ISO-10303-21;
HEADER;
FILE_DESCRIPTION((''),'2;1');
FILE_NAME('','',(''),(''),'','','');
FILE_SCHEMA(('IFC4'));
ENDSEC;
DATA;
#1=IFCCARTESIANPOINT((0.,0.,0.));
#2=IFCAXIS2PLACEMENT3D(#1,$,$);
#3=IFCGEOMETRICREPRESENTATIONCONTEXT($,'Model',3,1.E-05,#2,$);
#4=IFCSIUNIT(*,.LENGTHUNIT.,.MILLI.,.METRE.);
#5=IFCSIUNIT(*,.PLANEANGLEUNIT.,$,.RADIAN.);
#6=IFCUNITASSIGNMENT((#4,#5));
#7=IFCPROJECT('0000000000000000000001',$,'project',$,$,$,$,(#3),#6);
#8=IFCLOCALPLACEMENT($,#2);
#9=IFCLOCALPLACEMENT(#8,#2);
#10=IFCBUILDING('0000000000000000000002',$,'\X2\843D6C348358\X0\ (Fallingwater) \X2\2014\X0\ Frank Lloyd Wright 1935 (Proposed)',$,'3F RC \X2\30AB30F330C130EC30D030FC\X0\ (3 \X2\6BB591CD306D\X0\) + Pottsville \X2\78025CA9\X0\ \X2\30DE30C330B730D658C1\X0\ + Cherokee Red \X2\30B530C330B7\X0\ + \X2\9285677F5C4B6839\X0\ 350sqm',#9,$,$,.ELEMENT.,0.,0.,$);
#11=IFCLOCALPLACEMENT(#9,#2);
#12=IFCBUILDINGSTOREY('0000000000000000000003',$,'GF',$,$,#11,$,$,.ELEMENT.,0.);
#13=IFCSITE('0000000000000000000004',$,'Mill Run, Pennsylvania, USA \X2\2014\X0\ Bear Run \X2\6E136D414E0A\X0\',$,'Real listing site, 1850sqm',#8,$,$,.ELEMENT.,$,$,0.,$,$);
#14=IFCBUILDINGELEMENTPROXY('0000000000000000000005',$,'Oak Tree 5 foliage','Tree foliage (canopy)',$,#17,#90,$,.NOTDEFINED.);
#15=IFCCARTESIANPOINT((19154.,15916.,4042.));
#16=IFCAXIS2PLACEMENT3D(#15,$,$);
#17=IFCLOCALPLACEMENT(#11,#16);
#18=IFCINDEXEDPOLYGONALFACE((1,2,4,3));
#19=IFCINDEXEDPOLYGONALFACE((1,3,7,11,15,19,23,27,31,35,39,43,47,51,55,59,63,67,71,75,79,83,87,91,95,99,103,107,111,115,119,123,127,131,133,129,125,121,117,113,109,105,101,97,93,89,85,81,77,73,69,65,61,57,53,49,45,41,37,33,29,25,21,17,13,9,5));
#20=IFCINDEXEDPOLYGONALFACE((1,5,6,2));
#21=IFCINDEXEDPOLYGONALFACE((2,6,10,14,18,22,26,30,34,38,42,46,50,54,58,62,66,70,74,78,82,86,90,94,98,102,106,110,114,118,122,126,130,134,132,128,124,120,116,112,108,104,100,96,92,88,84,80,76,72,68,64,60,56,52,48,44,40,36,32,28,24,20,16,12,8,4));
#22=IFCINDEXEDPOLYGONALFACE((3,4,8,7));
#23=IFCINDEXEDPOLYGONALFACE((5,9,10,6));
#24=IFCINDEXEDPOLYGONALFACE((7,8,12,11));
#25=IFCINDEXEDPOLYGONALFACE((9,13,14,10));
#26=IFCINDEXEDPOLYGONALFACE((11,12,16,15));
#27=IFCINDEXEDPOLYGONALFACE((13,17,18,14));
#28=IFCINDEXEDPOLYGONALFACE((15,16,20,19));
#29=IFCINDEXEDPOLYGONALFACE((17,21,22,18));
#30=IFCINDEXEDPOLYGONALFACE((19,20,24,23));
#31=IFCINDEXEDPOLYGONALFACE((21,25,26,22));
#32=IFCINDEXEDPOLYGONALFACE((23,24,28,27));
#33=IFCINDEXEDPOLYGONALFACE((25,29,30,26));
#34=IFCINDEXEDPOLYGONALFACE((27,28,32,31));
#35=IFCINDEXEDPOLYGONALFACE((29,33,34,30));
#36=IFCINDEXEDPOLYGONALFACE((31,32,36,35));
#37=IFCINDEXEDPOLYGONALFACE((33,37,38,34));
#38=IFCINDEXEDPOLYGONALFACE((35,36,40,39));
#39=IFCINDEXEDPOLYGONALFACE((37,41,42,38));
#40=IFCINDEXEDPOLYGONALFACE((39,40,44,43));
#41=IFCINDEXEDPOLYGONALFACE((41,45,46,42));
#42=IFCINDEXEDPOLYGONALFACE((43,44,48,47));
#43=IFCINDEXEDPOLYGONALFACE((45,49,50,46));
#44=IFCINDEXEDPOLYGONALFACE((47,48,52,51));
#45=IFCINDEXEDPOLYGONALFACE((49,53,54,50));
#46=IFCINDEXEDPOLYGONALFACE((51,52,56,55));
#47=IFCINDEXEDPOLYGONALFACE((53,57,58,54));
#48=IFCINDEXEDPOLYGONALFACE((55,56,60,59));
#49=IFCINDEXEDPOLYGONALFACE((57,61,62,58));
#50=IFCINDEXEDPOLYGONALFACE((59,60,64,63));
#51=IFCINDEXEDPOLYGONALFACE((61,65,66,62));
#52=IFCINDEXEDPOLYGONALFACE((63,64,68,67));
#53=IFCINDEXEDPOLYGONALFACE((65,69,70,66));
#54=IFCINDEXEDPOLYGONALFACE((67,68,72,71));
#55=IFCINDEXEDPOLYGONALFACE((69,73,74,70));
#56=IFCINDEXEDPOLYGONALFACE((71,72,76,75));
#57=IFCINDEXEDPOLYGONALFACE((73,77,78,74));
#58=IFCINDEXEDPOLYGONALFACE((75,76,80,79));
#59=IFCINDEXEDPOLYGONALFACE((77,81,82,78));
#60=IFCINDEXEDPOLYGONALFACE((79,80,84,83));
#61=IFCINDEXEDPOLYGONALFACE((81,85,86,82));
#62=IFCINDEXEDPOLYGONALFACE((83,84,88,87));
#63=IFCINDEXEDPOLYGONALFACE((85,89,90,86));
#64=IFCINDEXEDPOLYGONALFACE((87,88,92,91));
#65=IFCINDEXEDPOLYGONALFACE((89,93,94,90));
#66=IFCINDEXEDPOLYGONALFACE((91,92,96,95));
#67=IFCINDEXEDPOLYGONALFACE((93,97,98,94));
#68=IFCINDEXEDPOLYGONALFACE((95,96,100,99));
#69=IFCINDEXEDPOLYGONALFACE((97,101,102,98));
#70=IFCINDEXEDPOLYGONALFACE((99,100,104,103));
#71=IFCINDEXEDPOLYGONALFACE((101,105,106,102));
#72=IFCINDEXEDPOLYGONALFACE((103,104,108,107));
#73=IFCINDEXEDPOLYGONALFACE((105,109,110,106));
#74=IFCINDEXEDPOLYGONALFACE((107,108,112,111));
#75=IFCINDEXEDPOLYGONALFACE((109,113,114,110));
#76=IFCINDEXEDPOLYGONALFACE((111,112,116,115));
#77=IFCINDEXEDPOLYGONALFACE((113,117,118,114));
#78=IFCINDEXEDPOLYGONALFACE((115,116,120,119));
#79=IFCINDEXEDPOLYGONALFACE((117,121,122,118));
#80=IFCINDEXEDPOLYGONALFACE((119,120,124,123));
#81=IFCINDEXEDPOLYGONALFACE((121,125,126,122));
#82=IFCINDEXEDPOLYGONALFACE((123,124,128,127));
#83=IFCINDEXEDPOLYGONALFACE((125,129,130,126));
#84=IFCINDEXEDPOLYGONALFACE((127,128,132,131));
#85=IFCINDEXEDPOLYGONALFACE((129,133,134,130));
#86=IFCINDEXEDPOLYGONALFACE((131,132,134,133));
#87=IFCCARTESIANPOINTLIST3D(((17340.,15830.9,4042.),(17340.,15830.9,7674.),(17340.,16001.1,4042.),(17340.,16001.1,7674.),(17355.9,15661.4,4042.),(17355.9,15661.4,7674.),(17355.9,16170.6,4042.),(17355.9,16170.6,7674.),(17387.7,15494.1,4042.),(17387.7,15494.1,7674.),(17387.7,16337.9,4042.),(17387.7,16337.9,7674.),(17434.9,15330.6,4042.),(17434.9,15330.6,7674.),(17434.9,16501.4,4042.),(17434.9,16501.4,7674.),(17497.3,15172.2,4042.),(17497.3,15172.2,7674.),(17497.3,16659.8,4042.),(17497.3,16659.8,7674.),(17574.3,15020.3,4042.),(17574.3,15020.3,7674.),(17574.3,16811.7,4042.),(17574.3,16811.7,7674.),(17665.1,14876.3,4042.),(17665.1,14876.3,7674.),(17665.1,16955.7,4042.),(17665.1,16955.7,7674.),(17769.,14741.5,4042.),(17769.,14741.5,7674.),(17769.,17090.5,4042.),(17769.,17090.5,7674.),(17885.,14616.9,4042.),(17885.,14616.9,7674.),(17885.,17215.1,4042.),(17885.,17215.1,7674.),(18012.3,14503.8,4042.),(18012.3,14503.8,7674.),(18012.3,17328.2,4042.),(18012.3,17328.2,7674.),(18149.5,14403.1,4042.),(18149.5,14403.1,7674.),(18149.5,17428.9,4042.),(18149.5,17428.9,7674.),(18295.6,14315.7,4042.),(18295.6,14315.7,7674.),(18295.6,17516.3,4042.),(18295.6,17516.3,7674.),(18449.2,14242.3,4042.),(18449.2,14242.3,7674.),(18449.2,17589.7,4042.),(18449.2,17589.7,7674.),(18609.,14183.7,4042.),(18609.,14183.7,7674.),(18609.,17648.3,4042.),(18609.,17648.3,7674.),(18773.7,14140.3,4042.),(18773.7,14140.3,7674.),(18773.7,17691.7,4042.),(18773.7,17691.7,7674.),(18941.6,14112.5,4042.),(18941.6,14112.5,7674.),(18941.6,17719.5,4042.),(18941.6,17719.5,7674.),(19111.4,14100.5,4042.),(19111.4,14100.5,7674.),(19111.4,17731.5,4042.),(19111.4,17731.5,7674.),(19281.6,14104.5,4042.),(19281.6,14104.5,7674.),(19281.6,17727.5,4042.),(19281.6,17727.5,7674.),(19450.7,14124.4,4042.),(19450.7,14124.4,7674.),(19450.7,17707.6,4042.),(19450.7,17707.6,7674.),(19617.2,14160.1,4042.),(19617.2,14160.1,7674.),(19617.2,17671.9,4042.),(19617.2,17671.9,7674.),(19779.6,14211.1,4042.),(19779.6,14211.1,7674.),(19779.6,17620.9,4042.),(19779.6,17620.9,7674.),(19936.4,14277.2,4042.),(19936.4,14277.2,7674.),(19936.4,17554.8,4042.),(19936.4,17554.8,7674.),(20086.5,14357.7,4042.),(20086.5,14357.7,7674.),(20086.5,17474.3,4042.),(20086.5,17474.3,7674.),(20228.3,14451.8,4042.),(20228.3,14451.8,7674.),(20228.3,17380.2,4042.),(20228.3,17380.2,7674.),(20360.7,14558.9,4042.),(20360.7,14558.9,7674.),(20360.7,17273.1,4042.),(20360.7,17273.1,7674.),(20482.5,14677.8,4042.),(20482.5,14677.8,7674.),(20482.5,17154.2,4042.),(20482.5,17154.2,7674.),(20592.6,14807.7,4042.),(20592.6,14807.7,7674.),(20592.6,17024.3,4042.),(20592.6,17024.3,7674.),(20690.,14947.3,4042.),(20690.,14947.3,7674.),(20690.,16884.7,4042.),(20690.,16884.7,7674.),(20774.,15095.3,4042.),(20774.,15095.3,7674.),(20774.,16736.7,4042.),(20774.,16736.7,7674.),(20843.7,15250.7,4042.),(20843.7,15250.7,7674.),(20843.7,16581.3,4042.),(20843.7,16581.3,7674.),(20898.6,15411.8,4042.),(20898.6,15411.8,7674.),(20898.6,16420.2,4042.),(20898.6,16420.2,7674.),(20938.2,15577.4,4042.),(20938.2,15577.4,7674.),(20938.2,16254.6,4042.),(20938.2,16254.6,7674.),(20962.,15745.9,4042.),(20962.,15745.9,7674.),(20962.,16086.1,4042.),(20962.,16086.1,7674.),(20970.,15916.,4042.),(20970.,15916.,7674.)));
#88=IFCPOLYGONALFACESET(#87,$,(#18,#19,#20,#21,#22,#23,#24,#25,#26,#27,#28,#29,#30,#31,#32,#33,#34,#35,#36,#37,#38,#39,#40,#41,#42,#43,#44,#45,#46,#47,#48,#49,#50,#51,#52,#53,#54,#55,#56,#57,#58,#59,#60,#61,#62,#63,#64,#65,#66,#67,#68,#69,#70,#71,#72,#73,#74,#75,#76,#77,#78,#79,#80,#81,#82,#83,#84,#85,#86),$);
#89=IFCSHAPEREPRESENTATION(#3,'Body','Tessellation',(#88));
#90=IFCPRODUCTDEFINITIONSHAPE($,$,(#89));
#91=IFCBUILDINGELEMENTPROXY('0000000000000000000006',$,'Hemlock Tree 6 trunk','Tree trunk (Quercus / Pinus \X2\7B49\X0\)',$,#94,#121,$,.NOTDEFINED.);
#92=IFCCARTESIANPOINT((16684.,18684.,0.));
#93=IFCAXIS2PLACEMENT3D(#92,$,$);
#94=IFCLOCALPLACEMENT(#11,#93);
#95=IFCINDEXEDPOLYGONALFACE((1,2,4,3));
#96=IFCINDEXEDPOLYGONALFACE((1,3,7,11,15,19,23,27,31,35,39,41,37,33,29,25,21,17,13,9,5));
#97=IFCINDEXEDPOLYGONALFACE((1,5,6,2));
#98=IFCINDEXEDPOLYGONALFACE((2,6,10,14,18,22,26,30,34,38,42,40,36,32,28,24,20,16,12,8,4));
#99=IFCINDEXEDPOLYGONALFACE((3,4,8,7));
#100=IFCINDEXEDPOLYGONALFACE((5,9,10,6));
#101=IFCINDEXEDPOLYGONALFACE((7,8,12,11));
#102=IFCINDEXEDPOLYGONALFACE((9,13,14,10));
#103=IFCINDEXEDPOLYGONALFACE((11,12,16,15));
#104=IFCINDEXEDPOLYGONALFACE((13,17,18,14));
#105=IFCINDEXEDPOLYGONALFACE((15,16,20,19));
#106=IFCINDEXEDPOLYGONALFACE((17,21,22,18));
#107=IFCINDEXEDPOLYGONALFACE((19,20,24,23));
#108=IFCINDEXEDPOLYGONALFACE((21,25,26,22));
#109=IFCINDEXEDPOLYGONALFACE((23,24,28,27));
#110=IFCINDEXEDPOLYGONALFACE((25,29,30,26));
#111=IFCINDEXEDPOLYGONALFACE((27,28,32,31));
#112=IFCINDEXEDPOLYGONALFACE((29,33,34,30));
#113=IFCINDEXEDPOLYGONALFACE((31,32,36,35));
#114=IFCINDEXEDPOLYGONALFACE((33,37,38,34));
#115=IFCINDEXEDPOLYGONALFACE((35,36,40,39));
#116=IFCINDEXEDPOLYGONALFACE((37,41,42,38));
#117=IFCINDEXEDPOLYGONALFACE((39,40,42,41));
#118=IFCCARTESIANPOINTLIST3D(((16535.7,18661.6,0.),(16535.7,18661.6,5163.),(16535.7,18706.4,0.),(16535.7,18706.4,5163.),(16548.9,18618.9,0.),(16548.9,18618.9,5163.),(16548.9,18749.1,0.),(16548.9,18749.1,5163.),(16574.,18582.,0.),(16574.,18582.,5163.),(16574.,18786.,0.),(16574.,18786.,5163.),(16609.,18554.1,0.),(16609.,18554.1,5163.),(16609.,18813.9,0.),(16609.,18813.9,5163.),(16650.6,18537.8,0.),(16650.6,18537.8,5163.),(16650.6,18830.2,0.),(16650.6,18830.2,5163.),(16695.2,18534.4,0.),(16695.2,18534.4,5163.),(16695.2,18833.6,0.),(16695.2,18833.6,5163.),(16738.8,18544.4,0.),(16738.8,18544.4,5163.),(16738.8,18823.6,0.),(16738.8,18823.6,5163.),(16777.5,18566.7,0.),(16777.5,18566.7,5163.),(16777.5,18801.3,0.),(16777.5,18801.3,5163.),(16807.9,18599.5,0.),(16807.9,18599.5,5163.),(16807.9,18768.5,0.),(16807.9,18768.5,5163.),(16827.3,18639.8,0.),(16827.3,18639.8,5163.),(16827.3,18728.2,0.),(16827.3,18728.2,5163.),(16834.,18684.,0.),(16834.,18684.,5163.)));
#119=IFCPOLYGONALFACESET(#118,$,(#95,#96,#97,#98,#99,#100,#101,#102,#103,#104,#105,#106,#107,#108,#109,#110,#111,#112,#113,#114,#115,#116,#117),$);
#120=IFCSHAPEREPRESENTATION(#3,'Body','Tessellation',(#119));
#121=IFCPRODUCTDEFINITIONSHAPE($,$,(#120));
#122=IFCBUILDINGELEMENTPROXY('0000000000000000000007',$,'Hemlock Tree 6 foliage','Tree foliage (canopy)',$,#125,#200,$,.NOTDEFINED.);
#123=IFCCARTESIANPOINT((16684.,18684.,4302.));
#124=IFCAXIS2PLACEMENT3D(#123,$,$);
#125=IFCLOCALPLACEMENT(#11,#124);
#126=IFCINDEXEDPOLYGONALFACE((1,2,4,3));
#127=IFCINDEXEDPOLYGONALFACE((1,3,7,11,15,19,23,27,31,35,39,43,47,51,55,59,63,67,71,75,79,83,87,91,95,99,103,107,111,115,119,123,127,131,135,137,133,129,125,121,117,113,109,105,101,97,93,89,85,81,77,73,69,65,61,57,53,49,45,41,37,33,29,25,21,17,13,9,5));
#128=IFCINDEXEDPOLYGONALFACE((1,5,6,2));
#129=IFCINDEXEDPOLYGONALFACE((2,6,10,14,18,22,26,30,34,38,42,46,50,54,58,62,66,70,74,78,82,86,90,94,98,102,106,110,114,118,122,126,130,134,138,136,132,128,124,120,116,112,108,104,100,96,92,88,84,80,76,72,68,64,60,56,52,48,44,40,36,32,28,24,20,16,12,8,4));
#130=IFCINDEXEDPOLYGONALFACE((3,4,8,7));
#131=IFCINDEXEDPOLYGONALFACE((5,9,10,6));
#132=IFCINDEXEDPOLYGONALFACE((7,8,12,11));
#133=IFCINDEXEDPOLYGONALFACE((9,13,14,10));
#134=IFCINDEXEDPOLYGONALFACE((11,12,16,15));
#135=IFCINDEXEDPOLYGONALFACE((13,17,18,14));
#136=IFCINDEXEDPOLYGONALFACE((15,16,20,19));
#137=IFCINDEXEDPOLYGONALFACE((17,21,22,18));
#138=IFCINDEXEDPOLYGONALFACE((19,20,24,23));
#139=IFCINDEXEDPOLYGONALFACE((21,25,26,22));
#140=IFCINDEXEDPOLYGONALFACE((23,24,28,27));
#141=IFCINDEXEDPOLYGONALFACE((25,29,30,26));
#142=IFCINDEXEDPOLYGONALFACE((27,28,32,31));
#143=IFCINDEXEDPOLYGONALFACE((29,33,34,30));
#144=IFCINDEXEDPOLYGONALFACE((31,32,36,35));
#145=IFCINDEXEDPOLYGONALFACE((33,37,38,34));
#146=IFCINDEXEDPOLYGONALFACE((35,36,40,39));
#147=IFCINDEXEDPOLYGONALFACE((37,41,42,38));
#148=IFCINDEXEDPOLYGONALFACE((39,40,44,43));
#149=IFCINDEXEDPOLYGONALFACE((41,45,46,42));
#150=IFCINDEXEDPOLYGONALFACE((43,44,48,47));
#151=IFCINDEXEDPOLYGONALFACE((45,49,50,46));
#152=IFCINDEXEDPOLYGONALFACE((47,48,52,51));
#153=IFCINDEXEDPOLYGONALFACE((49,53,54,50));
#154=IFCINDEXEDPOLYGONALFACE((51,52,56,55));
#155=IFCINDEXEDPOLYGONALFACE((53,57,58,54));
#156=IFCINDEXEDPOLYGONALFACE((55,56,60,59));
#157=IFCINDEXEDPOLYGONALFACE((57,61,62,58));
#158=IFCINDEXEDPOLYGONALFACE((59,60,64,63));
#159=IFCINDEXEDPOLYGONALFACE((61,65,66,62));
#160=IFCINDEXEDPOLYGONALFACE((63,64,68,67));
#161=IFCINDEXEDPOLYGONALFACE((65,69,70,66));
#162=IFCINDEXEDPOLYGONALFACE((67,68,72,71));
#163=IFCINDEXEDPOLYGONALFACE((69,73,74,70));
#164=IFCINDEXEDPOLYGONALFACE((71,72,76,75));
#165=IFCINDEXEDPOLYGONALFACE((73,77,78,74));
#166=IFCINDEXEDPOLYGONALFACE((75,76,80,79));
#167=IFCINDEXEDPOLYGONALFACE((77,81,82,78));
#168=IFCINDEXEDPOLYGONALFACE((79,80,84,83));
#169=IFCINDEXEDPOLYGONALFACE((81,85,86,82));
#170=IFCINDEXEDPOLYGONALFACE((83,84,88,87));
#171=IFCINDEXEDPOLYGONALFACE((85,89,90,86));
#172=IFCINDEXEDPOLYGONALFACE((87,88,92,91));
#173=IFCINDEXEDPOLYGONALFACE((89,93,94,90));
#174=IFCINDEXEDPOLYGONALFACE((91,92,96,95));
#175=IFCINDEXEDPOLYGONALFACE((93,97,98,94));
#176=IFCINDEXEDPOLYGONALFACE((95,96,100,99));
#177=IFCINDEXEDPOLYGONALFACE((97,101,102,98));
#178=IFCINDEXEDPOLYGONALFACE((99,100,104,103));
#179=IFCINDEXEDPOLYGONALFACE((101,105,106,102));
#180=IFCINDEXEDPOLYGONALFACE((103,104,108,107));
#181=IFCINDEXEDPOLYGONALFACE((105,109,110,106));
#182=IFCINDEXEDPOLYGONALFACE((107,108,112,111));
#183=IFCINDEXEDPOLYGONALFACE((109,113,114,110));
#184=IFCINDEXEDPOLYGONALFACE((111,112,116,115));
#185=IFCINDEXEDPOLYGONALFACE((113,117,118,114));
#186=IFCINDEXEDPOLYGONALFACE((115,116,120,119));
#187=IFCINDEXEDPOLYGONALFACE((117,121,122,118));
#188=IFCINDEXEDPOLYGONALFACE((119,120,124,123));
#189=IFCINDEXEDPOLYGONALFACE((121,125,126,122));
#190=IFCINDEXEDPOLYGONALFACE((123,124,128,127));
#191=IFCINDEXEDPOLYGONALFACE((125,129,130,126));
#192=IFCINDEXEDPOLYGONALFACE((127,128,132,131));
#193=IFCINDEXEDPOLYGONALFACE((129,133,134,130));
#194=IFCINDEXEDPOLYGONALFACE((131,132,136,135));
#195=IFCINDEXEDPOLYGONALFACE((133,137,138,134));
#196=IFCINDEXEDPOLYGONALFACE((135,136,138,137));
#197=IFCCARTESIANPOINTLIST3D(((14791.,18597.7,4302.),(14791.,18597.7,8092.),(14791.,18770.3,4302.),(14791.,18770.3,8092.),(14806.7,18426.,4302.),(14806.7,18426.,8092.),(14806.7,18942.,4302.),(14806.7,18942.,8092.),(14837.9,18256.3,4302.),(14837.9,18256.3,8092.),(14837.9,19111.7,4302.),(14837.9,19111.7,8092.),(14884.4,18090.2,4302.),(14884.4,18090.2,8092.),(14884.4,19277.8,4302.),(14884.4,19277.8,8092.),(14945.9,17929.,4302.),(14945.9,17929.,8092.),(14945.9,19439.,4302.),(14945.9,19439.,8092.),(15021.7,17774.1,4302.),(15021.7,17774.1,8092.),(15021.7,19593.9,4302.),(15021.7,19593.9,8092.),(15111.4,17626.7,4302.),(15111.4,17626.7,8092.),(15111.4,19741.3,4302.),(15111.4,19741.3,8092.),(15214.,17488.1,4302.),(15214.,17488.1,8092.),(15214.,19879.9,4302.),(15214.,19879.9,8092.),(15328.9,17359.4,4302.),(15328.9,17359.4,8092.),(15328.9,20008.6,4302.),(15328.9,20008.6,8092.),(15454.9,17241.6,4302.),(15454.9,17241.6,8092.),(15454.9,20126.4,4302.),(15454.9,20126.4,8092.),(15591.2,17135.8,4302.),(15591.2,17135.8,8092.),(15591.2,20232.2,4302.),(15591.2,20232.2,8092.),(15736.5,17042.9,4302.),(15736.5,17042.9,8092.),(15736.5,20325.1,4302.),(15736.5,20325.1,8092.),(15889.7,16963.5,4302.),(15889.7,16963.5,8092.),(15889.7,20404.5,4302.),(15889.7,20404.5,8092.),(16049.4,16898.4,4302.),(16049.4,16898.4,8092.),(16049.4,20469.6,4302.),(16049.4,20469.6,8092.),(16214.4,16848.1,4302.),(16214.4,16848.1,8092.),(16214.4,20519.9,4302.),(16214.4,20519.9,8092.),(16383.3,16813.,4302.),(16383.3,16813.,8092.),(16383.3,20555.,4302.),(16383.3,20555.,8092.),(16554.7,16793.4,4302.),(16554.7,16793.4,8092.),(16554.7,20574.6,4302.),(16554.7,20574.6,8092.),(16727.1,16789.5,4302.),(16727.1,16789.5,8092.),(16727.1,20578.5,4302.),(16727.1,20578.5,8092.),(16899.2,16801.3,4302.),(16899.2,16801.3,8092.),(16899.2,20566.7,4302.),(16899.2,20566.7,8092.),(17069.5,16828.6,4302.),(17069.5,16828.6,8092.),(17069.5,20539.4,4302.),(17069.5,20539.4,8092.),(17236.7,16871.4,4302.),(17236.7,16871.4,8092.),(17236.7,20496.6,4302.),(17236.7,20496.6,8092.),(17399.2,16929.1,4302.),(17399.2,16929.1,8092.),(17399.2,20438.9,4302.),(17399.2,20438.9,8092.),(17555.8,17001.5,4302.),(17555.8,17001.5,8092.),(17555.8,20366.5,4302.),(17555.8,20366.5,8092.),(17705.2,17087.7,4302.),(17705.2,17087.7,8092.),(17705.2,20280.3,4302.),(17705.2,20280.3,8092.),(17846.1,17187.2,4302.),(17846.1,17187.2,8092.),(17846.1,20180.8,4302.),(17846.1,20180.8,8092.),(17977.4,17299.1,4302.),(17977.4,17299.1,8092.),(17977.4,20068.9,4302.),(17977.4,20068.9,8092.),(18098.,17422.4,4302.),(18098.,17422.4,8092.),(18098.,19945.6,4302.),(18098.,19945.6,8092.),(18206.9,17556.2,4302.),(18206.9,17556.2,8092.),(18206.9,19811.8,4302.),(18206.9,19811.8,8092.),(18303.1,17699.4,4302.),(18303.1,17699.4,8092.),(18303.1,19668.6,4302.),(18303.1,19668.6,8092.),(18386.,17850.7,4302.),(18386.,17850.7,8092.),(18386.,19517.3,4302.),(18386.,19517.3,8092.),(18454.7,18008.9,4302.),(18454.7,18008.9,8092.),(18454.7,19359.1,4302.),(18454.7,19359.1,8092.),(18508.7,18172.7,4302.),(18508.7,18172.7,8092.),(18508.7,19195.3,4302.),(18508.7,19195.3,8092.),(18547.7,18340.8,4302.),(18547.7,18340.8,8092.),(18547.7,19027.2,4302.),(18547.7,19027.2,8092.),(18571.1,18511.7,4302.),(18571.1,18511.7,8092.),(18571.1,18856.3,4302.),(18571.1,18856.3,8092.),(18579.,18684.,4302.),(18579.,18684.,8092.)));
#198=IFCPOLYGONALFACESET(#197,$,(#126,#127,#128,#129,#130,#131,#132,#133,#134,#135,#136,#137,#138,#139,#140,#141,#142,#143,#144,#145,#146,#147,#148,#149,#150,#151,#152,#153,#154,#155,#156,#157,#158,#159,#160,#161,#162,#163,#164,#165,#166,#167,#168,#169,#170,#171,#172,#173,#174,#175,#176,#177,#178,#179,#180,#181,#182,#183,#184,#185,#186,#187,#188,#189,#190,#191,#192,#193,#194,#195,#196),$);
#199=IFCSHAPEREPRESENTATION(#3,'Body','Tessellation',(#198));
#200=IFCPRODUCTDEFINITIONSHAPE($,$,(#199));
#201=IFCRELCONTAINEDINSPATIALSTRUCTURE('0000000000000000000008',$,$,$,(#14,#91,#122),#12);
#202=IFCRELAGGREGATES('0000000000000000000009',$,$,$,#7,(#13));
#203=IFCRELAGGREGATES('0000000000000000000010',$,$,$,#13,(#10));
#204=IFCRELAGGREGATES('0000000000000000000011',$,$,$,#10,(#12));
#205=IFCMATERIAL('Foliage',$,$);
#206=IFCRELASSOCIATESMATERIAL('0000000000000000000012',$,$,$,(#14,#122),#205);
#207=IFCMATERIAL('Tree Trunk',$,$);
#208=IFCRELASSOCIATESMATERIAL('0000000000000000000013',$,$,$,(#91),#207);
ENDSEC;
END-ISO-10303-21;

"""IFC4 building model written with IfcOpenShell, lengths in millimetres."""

from ifc_helpers import new_model, si_unit, frame, origin, origin_2d, place, context, project, spatial, circle, extrude, material, element, save


model = new_model("IFC4")

# Units and contexts
model_context = context("Model", 3, precision=1e-05, world=origin())
ifc_project = project(units=[si_unit("LENGTHUNIT", "METRE", prefix="MILLI"), si_unit("PLANEANGLEUNIT", "RADIAN")], contexts=[model_context])

# Site, building, storey
site_placement = place(None, origin())
site = spatial("IfcSite", under=ifc_project, at=site_placement, Name="Mill Run, Pennsylvania, USA — Bear Run 渓流上", ObjectType="Real listing site, 1850sqm", CompositionType="ELEMENT", RefElevation=0.0)
building_placement = place(site_placement, origin())
building = spatial("IfcBuilding", under=site, at=building_placement, Name="落水荘 (Fallingwater) — Frank Lloyd Wright 1935 (Proposed)", ObjectType="3F RC カンチレバー (3 段重ね) + Pottsville 砂岩 マッシブ壁 + Cherokee Red サッシ + 銅板屋根 350sqm", CompositionType="ELEMENT", ElevationOfRefHeight=0.0, ElevationOfTerrain=0.0)
storey_placement = place(building_placement, origin())
storey = spatial("IfcBuildingStorey", under=building, at=storey_placement, Name="GF", CompositionType="ELEMENT", Elevation=0.0)

# Building element proxies
ifc_material_1 = material(Name="Tree Trunk")
ifc_material_2 = material(Name="Foliage")
proxy_1_placement = place(storey_placement, frame((19154.0, 15916.0, 4042.0)))
element("IfcBuildingElementProxy", 1, at=proxy_1_placement, inside=storey, material=ifc_material_2, Name="Oak Tree 5 foliage", Description="Tree foliage (canopy)", PredefinedType="NOTDEFINED", context=model_context, shape_type="SweptSolid", body=[
    extrude(circle(Radius=1816.0, at=origin_2d()), frame((19154.0, 15916.0, 4042.0)), (0.0, 0.0, 1.0), 3632.0),
])
proxy_2_placement = place(storey_placement, frame((16684.0, 18684.0, 0.0)))
element("IfcBuildingElementProxy", 2, at=proxy_2_placement, inside=storey, material=ifc_material_1, Name="Hemlock Tree 6 trunk", Description="Tree trunk (Quercus / Pinus 等)", PredefinedType="NOTDEFINED", context=model_context, shape_type="SweptSolid", body=[
    extrude(circle(Radius=150.0, at=origin_2d()), frame((16684.0, 18684.0, 0.0)), (0.0, 0.0, 1.0), 5163.0),
])
proxy_3_placement = place(storey_placement, frame((16684.0, 18684.0, 4302.0)))
element("IfcBuildingElementProxy", 3, at=proxy_3_placement, inside=storey, material=ifc_material_2, Name="Hemlock Tree 6 foliage", Description="Tree foliage (canopy)", PredefinedType="NOTDEFINED", context=model_context, shape_type="SweptSolid", body=[
    extrude(circle(Radius=1895.0, at=origin_2d()), frame((16684.0, 18684.0, 4302.0)), (0.0, 0.0, 1.0), 3790.0),
])

save(model, "model.ifc")
